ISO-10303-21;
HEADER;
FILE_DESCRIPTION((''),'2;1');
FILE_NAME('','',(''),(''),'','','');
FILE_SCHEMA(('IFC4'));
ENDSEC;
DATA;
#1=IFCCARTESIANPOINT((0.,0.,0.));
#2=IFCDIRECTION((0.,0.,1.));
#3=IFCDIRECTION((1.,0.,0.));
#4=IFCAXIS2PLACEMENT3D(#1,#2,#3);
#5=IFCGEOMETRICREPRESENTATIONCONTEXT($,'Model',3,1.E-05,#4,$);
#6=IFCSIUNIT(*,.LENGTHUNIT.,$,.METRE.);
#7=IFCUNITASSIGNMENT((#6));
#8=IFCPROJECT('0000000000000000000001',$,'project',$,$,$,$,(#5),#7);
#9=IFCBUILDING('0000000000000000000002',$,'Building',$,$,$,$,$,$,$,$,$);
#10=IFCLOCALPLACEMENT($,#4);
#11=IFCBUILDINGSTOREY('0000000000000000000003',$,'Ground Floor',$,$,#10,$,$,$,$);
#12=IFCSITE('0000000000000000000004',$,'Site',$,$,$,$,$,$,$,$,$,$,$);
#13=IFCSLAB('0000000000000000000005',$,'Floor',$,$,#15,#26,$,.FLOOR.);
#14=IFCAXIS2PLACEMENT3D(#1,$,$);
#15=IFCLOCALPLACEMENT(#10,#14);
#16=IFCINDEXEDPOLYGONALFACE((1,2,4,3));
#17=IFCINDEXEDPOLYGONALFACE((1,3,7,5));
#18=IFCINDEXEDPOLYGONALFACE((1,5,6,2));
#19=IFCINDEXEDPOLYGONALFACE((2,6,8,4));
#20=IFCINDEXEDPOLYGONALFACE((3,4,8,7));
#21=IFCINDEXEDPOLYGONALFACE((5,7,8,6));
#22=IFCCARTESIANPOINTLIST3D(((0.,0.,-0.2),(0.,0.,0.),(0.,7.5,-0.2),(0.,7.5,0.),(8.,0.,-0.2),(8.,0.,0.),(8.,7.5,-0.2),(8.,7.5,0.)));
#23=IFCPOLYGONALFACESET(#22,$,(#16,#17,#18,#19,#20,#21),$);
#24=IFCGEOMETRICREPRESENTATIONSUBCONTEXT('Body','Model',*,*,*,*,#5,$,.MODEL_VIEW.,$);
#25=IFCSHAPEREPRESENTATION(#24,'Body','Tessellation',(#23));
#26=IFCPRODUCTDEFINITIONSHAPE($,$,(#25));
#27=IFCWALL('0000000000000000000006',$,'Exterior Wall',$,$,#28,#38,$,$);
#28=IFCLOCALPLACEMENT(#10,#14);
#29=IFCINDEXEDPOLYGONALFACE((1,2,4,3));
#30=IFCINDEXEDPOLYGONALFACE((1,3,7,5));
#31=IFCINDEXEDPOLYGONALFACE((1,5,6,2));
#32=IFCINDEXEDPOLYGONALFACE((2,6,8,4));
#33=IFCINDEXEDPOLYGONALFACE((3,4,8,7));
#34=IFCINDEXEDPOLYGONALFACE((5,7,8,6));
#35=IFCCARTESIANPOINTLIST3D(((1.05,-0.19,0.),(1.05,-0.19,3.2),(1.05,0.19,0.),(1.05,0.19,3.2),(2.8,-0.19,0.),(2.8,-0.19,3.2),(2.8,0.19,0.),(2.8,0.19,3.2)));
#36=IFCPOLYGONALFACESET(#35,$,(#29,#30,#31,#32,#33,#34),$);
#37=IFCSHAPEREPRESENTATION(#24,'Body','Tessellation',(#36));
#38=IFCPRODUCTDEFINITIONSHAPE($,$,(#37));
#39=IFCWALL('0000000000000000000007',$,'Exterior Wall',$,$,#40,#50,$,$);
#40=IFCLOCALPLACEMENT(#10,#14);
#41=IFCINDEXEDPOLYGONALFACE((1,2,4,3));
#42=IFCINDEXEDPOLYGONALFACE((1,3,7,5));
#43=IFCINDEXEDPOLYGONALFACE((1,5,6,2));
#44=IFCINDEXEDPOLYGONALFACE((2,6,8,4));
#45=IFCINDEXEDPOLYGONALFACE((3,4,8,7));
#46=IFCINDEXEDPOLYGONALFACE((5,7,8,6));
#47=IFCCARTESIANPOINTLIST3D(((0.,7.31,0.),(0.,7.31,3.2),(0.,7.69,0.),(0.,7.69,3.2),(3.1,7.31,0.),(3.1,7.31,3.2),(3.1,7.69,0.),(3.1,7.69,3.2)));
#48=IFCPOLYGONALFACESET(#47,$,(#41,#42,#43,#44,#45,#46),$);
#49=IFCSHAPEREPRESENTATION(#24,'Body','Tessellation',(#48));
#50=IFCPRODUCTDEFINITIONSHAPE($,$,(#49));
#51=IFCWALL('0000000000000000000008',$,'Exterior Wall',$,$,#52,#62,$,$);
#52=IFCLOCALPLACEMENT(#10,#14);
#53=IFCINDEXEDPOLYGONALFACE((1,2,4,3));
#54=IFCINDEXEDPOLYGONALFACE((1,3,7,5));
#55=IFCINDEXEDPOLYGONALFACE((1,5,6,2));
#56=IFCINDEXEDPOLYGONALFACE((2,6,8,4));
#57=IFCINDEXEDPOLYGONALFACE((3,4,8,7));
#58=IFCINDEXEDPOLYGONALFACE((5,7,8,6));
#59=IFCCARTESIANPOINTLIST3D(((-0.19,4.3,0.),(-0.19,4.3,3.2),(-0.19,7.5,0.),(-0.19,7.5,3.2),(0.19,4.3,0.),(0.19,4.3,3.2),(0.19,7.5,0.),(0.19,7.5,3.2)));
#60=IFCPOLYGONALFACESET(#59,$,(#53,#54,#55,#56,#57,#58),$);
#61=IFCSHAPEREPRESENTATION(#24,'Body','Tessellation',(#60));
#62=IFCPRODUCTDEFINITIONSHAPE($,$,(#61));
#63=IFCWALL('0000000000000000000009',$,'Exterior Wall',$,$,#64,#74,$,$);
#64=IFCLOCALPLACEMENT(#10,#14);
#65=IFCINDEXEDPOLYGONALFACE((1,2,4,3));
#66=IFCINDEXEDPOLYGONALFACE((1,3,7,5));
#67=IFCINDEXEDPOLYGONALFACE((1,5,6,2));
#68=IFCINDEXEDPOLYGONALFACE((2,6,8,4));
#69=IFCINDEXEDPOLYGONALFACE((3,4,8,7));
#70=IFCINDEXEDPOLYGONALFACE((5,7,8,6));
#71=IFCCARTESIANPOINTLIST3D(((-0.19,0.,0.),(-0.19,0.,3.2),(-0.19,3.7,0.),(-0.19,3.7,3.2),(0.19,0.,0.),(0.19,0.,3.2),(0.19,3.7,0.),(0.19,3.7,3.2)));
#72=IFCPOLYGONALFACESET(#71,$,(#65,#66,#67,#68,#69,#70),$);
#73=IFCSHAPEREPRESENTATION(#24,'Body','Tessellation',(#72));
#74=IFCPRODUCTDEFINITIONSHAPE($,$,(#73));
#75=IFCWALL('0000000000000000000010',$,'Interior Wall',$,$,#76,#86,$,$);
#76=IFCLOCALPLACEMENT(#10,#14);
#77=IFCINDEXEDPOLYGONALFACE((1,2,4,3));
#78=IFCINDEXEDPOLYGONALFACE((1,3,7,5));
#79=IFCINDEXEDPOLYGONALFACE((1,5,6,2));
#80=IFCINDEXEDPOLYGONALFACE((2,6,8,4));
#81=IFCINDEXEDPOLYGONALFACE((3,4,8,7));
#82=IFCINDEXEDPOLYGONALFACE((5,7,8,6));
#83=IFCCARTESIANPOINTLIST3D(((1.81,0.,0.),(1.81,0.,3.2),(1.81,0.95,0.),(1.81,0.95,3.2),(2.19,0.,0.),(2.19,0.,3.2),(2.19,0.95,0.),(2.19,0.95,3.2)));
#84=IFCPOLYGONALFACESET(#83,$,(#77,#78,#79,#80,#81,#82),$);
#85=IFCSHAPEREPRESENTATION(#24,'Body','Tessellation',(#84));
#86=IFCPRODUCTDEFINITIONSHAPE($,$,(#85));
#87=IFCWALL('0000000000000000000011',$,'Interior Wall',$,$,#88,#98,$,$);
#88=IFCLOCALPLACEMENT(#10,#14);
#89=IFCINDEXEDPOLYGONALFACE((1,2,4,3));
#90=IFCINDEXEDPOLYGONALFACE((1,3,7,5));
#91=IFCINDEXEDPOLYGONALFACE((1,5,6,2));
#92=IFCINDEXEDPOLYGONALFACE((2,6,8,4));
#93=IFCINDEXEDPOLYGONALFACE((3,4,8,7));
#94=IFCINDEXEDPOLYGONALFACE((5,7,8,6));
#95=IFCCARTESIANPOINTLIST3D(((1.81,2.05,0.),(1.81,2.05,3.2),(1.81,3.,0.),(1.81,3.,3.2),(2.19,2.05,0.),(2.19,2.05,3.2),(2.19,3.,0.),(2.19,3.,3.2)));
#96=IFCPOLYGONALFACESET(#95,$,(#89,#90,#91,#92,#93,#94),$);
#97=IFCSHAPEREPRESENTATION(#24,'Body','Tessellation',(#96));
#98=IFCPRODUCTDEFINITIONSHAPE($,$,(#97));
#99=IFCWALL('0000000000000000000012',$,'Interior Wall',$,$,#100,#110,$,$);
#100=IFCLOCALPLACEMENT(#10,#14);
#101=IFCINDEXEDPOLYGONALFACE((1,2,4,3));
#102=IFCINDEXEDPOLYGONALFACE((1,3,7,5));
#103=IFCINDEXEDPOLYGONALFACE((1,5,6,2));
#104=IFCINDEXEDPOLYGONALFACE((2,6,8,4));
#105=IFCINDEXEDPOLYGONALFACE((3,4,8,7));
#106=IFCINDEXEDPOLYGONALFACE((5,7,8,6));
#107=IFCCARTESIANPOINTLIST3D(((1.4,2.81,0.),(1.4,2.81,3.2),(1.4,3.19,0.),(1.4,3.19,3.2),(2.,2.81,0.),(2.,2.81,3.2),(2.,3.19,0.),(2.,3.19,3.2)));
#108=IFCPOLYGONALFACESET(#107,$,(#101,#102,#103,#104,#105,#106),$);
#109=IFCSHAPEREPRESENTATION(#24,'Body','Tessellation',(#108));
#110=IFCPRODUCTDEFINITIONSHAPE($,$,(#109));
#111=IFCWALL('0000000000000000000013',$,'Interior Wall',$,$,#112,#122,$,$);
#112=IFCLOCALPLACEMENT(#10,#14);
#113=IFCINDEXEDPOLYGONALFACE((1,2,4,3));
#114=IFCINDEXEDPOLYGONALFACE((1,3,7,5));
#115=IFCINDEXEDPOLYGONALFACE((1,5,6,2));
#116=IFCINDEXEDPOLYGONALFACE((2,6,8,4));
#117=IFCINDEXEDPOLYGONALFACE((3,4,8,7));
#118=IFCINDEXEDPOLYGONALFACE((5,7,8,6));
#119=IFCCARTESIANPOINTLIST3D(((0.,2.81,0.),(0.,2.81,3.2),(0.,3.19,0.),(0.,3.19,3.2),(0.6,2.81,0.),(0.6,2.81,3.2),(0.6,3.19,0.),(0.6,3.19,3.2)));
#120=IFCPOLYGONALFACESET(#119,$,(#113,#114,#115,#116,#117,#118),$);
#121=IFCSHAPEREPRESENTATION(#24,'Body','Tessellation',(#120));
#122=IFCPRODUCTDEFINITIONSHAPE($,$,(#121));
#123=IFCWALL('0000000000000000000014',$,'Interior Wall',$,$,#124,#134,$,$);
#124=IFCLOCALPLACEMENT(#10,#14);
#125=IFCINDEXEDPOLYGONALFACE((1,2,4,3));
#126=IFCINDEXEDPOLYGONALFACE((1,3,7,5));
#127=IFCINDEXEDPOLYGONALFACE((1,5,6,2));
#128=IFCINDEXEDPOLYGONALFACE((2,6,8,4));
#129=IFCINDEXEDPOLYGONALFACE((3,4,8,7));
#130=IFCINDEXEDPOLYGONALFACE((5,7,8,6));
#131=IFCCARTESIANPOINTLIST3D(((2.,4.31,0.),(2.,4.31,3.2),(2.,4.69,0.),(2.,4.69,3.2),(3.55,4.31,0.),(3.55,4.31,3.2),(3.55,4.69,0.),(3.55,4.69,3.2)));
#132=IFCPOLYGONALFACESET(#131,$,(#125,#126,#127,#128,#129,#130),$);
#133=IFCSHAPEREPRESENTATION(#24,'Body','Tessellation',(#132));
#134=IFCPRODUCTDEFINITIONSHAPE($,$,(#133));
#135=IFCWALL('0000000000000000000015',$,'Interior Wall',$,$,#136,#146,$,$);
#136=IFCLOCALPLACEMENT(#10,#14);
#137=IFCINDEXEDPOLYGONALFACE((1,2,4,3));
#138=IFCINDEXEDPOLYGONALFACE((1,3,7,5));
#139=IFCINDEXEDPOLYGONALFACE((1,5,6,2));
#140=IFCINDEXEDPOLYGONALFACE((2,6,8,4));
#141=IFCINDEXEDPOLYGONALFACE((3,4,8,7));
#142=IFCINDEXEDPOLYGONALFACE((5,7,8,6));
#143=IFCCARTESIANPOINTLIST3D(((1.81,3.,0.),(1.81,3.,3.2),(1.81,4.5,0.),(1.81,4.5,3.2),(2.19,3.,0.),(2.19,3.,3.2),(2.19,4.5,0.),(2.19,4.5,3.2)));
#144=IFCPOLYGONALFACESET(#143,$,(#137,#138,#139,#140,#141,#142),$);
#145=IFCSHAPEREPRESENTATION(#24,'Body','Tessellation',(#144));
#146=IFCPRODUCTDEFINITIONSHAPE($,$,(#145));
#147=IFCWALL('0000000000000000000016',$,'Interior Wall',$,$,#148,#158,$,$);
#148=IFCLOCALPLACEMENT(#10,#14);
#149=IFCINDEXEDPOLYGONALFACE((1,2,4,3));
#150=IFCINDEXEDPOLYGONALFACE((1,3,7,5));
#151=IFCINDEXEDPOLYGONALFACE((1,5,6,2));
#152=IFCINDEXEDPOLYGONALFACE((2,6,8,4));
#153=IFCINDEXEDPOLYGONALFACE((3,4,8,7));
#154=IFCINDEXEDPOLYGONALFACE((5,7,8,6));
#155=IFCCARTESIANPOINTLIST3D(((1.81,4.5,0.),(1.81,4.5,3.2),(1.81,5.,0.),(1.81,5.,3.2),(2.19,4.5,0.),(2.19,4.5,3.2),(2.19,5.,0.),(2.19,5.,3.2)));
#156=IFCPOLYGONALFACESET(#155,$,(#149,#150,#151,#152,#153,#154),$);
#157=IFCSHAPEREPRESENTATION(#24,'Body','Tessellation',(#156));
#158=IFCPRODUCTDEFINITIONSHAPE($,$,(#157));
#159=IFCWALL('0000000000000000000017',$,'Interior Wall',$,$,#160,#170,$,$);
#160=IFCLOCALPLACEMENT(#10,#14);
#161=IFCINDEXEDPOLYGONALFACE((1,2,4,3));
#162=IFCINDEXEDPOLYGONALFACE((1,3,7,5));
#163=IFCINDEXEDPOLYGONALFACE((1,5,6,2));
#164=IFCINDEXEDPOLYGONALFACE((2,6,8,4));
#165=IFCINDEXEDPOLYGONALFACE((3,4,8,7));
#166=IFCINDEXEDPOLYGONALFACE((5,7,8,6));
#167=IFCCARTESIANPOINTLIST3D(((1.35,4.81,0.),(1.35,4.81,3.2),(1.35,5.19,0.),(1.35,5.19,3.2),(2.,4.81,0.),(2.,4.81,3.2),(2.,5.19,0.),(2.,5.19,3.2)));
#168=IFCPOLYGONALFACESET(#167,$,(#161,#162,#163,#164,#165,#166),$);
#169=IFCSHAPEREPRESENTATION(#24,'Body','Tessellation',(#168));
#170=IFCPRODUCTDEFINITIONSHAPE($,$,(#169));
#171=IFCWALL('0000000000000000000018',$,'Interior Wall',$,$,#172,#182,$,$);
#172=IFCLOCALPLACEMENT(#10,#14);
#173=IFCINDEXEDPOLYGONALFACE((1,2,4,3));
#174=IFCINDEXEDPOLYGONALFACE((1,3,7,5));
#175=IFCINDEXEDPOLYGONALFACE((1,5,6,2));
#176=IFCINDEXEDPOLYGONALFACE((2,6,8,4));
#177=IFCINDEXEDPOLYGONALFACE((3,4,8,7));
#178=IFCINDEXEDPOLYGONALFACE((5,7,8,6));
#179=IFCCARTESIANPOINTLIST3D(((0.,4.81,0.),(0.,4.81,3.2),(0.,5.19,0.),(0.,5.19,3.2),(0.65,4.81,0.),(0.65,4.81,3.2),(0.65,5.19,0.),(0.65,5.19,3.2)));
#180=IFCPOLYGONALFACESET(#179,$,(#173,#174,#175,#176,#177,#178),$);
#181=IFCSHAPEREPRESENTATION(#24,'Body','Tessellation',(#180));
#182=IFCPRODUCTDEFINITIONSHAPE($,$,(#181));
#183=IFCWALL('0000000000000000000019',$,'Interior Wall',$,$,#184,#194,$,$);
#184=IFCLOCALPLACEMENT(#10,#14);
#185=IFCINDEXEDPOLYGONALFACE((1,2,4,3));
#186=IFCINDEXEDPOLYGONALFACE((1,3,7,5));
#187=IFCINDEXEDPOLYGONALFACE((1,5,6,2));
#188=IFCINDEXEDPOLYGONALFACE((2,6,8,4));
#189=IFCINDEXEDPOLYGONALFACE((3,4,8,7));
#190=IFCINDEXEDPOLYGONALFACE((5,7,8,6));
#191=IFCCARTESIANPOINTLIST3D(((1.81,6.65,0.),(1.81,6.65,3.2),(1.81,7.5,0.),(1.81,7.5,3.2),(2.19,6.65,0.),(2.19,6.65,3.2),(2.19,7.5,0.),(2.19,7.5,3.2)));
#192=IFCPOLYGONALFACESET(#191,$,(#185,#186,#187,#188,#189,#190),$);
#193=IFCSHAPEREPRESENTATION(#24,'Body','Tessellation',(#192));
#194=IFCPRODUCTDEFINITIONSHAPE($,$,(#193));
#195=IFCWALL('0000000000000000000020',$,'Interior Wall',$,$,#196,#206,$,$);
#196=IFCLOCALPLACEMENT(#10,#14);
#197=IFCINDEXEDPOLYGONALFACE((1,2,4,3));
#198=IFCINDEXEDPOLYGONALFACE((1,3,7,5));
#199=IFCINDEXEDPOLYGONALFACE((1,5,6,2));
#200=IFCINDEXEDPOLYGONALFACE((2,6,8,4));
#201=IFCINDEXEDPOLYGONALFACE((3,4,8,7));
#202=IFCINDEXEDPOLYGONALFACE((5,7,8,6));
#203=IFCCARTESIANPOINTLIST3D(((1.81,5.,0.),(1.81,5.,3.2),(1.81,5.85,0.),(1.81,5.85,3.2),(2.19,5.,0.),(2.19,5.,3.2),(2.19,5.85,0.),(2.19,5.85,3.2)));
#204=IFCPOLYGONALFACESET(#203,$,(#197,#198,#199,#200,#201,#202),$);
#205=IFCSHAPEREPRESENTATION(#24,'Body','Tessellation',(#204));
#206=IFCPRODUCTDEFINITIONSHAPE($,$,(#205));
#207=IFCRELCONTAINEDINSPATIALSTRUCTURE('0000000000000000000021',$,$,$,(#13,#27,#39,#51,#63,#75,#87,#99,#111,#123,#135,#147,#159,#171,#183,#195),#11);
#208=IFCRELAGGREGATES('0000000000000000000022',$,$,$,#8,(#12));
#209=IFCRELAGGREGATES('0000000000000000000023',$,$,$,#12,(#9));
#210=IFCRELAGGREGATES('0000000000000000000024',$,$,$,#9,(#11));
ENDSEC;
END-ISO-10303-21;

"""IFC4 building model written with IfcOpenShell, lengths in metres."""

from ifc_helpers import new_model, si_unit, frame, origin_with_axes, place, context, subcontext, project, spatial, indexed_curve, outline, extrude, element, save


model = new_model("IFC4")

# Units and contexts
model_context = context("Model", 3, precision=1e-05, world=origin_with_axes())
body_context = subcontext(model_context, "Body", "Model", "MODEL_VIEW")
ifc_project = project(units=[si_unit("LENGTHUNIT", "METRE")], contexts=[model_context])

# Site, building, storey
site = spatial("IfcSite", under=ifc_project, Name="Site")
building = spatial("IfcBuilding", under=site, Name="Building")
storey_placement = place(None, origin_with_axes())
storey = spatial("IfcBuildingStorey", under=building, at=storey_placement, Name="Ground Floor")

# Slab
slab_placement = place(storey_placement, frame((0.0, 0.0, -0.2), z_axis=(0.0, 0.0, 1.0), x_axis=(1.0, 0.0, 0.0)))
element("IfcSlab", 1, at=slab_placement, inside=storey, Name="Floor", PredefinedType="FLOOR", context=body_context, shape_type="SweptSolid", body=[
    extrude(outline(indexed_curve([(0.0, 0.0), (8.0, 0.0), (8.0, 7.5), (0.0, 7.5)])), None, (0.0, 0.0, 1.0), 0.2),
])

# Walls
wall_1_placement = place(storey_placement, frame((1.05, 0.0, 0.0), z_axis=(0.0, 0.0, 1.0), x_axis=(1.0, 0.0, 0.0)))
element("IfcWall", 2, at=wall_1_placement, inside=storey, Name="Exterior Wall", context=body_context, shape_type="SweptSolid", body=[
    extrude(outline(indexed_curve([(0.0, 0.0), (0.0, 0.38), (1.75, 0.38), (1.75, 0.0), (0.0, 0.0)], self_intersect=False)), frame((0.0, -0.19, 0.0), z_axis=(0.0, 0.0, 1.0), x_axis=(1.0, 0.0, 0.0)), (0.0, 0.0, 1.0), 3.2),
])
wall_2_placement = place(storey_placement, frame((3.1, 7.5, 0.0), z_axis=(0.0, 0.0, 1.0), x_axis=(-1.0, 0.0, 0.0)))
element("IfcWall", 3, at=wall_2_placement, inside=storey, Name="Exterior Wall", context=body_context, shape_type="SweptSolid", body=[
    extrude(outline(indexed_curve([(0.0, 0.0), (0.0, 0.38), (3.1, 0.38), (3.1, 0.0), (0.0, 0.0)], self_intersect=False)), frame((0.0, -0.19, 0.0), z_axis=(0.0, 0.0, 1.0), x_axis=(1.0, 0.0, 0.0)), (0.0, 0.0, 1.0), 3.2),
])
wall_3_placement = place(storey_placement, frame((0.0, 7.5, 0.0), z_axis=(0.0, 0.0, 1.0), x_axis=(0.0, -1.0, 0.0)))
element("IfcWall", 4, at=wall_3_placement, inside=storey, Name="Exterior Wall", context=body_context, shape_type="SweptSolid", body=[
    extrude(outline(indexed_curve([(0.0, 0.0), (0.0, 0.38), (3.2, 0.38), (3.2, 0.0), (0.0, 0.0)], self_intersect=False)), frame((0.0, -0.19, 0.0), z_axis=(0.0, 0.0, 1.0), x_axis=(1.0, 0.0, 0.0)), (0.0, 0.0, 1.0), 3.2),
])
wall_4_placement = place(storey_placement, frame((0.0, 3.7, 0.0), z_axis=(0.0, 0.0, 1.0), x_axis=(0.0, -1.0, 0.0)))
element("IfcWall", 5, at=wall_4_placement, inside=storey, Name="Exterior Wall", context=body_context, shape_type="SweptSolid", body=[
    extrude(outline(indexed_curve([(0.0, 0.0), (0.0, 0.38), (3.7, 0.38), (3.7, 0.0), (0.0, 0.0)], self_intersect=False)), frame((0.0, -0.19, 0.0), z_axis=(0.0, 0.0, 1.0), x_axis=(1.0, 0.0, 0.0)), (0.0, 0.0, 1.0), 3.2),
])
wall_5_placement = place(storey_placement, frame((2.0, 0.0, 0.0), z_axis=(0.0, 0.0, 1.0), x_axis=(0.0, 1.0, 0.0)))
element("IfcWall", 6, at=wall_5_placement, inside=storey, Name="Interior Wall", context=body_context, shape_type="SweptSolid", body=[
    extrude(outline(indexed_curve([(0.0, 0.0), (0.0, 0.38), (0.95, 0.38), (0.95, 0.0), (0.0, 0.0)], self_intersect=False)), frame((0.0, -0.19, 0.0), z_axis=(0.0, 0.0, 1.0), x_axis=(1.0, 0.0, 0.0)), (0.0, 0.0, 1.0), 3.2),
])
wall_6_placement = place(storey_placement, frame((2.0, 2.05, 0.0), z_axis=(0.0, 0.0, 1.0), x_axis=(0.0, 1.0, 0.0)))
element("IfcWall", 7, at=wall_6_placement, inside=storey, Name="Interior Wall", context=body_context, shape_type="SweptSolid", body=[
    extrude(outline(indexed_curve([(0.0, 0.0), (0.0, 0.38), (0.95, 0.38), (0.95, 0.0), (0.0, 0.0)], self_intersect=False)), frame((0.0, -0.19, 0.0), z_axis=(0.0, 0.0, 1.0), x_axis=(1.0, 0.0, 0.0)), (0.0, 0.0, 1.0), 3.2),
])
for number, where, z_axis, x_axis, name in (
    (8, (2.0, 3.0, 0.0), (0.0, 0.0, 1.0), (-1.0, 0.0, 0.0), "Interior Wall"),
    (9, (0.6, 3.0, 0.0), (0.0, 0.0, 1.0), (-1.0, 0.0, 0.0), "Interior Wall"),
):
    element("IfcWall", number, at=place(storey_placement, frame(where, z_axis=z_axis, x_axis=x_axis)), inside=storey, Name=name, context=body_context, shape_type="SweptSolid", body=[
        extrude(outline(indexed_curve([(0.0, 0.0), (0.0, 0.38), (0.6, 0.38), (0.6, 0.0), (0.0, 0.0)], self_intersect=False)), frame((0.0, -0.19, 0.0), z_axis=(0.0, 0.0, 1.0), x_axis=(1.0, 0.0, 0.0)), (0.0, 0.0, 1.0), 3.2),
    ])
wall_7_placement = place(storey_placement, frame((3.55, 4.5, 0.0), z_axis=(0.0, 0.0, 1.0), x_axis=(-1.0, 0.0, 0.0)))
element("IfcWall", 10, at=wall_7_placement, inside=storey, Name="Interior Wall", context=body_context, shape_type="SweptSolid", body=[
    extrude(outline(indexed_curve([(0.0, 0.0), (0.0, 0.38), (1.55, 0.38), (1.55, 0.0), (0.0, 0.0)], self_intersect=False)), frame((0.0, -0.19, 0.0), z_axis=(0.0, 0.0, 1.0), x_axis=(1.0, 0.0, 0.0)), (0.0, 0.0, 1.0), 3.2),
])
wall_8_placement = place(storey_placement, frame((2.0, 4.5, 0.0), z_axis=(0.0, 0.0, 1.0), x_axis=(0.0, -1.0, 0.0)))
element("IfcWall", 11, at=wall_8_placement, inside=storey, Name="Interior Wall", context=body_context, shape_type="SweptSolid", body=[
    extrude(outline(indexed_curve([(0.0, 0.0), (0.0, 0.38), (1.5, 0.38), (1.5, 0.0), (0.0, 0.0)], self_intersect=False)), frame((0.0, -0.19, 0.0), z_axis=(0.0, 0.0, 1.0), x_axis=(1.0, 0.0, 0.0)), (0.0, 0.0, 1.0), 3.2),
])
wall_9_placement = place(storey_placement, frame((2.0, 4.5, 0.0), z_axis=(0.0, 0.0, 1.0), x_axis=(0.0, 1.0, 0.0)))
element("IfcWall", 12, at=wall_9_placement, inside=storey, Name="Interior Wall", context=body_context, shape_type="SweptSolid", body=[
    extrude(outline(indexed_curve([(0.0, 0.0), (0.0, 0.38), (0.5, 0.38), (0.5, 0.0), (0.0, 0.0)], self_intersect=False)), frame((0.0, -0.19, 0.0), z_axis=(0.0, 0.0, 1.0), x_axis=(1.0, 0.0, 0.0)), (0.0, 0.0, 1.0), 3.2),
])
for number, where, z_axis, x_axis, name in (
    (13, (2.0, 5.0, 0.0), (0.0, 0.0, 1.0), (-1.0, 0.0, 0.0), "Interior Wall"),
    (14, (0.65, 5.0, 0.0), (0.0, 0.0, 1.0), (-1.0, 0.0, 0.0), "Interior Wall"),
):
    element("IfcWall", number, at=place(storey_placement, frame(where, z_axis=z_axis, x_axis=x_axis)), inside=storey, Name=name, context=body_context, shape_type="SweptSolid", body=[
        extrude(outline(indexed_curve([(0.0, 0.0), (0.0, 0.38), (0.65, 0.38), (0.65, 0.0), (0.0, 0.0)], self_intersect=False)), frame((0.0, -0.19, 0.0), z_axis=(0.0, 0.0, 1.0), x_axis=(1.0, 0.0, 0.0)), (0.0, 0.0, 1.0), 3.2),
    ])
for number, where, z_axis, x_axis, name in (
    (15, (2.0, 7.5, 0.0), (0.0, 0.0, 1.0), (0.0, -1.0, 0.0), "Interior Wall"),
    (16, (2.0, 5.85, 0.0), (0.0, 0.0, 1.0), (0.0, -1.0, 0.0), "Interior Wall"),
):
    element("IfcWall", number, at=place(storey_placement, frame(where, z_axis=z_axis, x_axis=x_axis)), inside=storey, Name=name, context=body_context, shape_type="SweptSolid", body=[
        extrude(outline(indexed_curve([(0.0, 0.0), (0.0, 0.38), (0.85, 0.38), (0.85, 0.0), (0.0, 0.0)], self_intersect=False)), frame((0.0, -0.19, 0.0), z_axis=(0.0, 0.0, 1.0), x_axis=(1.0, 0.0, 0.0)), (0.0, 0.0, 1.0), 3.2),
    ])

save(model, "model.ifc")
